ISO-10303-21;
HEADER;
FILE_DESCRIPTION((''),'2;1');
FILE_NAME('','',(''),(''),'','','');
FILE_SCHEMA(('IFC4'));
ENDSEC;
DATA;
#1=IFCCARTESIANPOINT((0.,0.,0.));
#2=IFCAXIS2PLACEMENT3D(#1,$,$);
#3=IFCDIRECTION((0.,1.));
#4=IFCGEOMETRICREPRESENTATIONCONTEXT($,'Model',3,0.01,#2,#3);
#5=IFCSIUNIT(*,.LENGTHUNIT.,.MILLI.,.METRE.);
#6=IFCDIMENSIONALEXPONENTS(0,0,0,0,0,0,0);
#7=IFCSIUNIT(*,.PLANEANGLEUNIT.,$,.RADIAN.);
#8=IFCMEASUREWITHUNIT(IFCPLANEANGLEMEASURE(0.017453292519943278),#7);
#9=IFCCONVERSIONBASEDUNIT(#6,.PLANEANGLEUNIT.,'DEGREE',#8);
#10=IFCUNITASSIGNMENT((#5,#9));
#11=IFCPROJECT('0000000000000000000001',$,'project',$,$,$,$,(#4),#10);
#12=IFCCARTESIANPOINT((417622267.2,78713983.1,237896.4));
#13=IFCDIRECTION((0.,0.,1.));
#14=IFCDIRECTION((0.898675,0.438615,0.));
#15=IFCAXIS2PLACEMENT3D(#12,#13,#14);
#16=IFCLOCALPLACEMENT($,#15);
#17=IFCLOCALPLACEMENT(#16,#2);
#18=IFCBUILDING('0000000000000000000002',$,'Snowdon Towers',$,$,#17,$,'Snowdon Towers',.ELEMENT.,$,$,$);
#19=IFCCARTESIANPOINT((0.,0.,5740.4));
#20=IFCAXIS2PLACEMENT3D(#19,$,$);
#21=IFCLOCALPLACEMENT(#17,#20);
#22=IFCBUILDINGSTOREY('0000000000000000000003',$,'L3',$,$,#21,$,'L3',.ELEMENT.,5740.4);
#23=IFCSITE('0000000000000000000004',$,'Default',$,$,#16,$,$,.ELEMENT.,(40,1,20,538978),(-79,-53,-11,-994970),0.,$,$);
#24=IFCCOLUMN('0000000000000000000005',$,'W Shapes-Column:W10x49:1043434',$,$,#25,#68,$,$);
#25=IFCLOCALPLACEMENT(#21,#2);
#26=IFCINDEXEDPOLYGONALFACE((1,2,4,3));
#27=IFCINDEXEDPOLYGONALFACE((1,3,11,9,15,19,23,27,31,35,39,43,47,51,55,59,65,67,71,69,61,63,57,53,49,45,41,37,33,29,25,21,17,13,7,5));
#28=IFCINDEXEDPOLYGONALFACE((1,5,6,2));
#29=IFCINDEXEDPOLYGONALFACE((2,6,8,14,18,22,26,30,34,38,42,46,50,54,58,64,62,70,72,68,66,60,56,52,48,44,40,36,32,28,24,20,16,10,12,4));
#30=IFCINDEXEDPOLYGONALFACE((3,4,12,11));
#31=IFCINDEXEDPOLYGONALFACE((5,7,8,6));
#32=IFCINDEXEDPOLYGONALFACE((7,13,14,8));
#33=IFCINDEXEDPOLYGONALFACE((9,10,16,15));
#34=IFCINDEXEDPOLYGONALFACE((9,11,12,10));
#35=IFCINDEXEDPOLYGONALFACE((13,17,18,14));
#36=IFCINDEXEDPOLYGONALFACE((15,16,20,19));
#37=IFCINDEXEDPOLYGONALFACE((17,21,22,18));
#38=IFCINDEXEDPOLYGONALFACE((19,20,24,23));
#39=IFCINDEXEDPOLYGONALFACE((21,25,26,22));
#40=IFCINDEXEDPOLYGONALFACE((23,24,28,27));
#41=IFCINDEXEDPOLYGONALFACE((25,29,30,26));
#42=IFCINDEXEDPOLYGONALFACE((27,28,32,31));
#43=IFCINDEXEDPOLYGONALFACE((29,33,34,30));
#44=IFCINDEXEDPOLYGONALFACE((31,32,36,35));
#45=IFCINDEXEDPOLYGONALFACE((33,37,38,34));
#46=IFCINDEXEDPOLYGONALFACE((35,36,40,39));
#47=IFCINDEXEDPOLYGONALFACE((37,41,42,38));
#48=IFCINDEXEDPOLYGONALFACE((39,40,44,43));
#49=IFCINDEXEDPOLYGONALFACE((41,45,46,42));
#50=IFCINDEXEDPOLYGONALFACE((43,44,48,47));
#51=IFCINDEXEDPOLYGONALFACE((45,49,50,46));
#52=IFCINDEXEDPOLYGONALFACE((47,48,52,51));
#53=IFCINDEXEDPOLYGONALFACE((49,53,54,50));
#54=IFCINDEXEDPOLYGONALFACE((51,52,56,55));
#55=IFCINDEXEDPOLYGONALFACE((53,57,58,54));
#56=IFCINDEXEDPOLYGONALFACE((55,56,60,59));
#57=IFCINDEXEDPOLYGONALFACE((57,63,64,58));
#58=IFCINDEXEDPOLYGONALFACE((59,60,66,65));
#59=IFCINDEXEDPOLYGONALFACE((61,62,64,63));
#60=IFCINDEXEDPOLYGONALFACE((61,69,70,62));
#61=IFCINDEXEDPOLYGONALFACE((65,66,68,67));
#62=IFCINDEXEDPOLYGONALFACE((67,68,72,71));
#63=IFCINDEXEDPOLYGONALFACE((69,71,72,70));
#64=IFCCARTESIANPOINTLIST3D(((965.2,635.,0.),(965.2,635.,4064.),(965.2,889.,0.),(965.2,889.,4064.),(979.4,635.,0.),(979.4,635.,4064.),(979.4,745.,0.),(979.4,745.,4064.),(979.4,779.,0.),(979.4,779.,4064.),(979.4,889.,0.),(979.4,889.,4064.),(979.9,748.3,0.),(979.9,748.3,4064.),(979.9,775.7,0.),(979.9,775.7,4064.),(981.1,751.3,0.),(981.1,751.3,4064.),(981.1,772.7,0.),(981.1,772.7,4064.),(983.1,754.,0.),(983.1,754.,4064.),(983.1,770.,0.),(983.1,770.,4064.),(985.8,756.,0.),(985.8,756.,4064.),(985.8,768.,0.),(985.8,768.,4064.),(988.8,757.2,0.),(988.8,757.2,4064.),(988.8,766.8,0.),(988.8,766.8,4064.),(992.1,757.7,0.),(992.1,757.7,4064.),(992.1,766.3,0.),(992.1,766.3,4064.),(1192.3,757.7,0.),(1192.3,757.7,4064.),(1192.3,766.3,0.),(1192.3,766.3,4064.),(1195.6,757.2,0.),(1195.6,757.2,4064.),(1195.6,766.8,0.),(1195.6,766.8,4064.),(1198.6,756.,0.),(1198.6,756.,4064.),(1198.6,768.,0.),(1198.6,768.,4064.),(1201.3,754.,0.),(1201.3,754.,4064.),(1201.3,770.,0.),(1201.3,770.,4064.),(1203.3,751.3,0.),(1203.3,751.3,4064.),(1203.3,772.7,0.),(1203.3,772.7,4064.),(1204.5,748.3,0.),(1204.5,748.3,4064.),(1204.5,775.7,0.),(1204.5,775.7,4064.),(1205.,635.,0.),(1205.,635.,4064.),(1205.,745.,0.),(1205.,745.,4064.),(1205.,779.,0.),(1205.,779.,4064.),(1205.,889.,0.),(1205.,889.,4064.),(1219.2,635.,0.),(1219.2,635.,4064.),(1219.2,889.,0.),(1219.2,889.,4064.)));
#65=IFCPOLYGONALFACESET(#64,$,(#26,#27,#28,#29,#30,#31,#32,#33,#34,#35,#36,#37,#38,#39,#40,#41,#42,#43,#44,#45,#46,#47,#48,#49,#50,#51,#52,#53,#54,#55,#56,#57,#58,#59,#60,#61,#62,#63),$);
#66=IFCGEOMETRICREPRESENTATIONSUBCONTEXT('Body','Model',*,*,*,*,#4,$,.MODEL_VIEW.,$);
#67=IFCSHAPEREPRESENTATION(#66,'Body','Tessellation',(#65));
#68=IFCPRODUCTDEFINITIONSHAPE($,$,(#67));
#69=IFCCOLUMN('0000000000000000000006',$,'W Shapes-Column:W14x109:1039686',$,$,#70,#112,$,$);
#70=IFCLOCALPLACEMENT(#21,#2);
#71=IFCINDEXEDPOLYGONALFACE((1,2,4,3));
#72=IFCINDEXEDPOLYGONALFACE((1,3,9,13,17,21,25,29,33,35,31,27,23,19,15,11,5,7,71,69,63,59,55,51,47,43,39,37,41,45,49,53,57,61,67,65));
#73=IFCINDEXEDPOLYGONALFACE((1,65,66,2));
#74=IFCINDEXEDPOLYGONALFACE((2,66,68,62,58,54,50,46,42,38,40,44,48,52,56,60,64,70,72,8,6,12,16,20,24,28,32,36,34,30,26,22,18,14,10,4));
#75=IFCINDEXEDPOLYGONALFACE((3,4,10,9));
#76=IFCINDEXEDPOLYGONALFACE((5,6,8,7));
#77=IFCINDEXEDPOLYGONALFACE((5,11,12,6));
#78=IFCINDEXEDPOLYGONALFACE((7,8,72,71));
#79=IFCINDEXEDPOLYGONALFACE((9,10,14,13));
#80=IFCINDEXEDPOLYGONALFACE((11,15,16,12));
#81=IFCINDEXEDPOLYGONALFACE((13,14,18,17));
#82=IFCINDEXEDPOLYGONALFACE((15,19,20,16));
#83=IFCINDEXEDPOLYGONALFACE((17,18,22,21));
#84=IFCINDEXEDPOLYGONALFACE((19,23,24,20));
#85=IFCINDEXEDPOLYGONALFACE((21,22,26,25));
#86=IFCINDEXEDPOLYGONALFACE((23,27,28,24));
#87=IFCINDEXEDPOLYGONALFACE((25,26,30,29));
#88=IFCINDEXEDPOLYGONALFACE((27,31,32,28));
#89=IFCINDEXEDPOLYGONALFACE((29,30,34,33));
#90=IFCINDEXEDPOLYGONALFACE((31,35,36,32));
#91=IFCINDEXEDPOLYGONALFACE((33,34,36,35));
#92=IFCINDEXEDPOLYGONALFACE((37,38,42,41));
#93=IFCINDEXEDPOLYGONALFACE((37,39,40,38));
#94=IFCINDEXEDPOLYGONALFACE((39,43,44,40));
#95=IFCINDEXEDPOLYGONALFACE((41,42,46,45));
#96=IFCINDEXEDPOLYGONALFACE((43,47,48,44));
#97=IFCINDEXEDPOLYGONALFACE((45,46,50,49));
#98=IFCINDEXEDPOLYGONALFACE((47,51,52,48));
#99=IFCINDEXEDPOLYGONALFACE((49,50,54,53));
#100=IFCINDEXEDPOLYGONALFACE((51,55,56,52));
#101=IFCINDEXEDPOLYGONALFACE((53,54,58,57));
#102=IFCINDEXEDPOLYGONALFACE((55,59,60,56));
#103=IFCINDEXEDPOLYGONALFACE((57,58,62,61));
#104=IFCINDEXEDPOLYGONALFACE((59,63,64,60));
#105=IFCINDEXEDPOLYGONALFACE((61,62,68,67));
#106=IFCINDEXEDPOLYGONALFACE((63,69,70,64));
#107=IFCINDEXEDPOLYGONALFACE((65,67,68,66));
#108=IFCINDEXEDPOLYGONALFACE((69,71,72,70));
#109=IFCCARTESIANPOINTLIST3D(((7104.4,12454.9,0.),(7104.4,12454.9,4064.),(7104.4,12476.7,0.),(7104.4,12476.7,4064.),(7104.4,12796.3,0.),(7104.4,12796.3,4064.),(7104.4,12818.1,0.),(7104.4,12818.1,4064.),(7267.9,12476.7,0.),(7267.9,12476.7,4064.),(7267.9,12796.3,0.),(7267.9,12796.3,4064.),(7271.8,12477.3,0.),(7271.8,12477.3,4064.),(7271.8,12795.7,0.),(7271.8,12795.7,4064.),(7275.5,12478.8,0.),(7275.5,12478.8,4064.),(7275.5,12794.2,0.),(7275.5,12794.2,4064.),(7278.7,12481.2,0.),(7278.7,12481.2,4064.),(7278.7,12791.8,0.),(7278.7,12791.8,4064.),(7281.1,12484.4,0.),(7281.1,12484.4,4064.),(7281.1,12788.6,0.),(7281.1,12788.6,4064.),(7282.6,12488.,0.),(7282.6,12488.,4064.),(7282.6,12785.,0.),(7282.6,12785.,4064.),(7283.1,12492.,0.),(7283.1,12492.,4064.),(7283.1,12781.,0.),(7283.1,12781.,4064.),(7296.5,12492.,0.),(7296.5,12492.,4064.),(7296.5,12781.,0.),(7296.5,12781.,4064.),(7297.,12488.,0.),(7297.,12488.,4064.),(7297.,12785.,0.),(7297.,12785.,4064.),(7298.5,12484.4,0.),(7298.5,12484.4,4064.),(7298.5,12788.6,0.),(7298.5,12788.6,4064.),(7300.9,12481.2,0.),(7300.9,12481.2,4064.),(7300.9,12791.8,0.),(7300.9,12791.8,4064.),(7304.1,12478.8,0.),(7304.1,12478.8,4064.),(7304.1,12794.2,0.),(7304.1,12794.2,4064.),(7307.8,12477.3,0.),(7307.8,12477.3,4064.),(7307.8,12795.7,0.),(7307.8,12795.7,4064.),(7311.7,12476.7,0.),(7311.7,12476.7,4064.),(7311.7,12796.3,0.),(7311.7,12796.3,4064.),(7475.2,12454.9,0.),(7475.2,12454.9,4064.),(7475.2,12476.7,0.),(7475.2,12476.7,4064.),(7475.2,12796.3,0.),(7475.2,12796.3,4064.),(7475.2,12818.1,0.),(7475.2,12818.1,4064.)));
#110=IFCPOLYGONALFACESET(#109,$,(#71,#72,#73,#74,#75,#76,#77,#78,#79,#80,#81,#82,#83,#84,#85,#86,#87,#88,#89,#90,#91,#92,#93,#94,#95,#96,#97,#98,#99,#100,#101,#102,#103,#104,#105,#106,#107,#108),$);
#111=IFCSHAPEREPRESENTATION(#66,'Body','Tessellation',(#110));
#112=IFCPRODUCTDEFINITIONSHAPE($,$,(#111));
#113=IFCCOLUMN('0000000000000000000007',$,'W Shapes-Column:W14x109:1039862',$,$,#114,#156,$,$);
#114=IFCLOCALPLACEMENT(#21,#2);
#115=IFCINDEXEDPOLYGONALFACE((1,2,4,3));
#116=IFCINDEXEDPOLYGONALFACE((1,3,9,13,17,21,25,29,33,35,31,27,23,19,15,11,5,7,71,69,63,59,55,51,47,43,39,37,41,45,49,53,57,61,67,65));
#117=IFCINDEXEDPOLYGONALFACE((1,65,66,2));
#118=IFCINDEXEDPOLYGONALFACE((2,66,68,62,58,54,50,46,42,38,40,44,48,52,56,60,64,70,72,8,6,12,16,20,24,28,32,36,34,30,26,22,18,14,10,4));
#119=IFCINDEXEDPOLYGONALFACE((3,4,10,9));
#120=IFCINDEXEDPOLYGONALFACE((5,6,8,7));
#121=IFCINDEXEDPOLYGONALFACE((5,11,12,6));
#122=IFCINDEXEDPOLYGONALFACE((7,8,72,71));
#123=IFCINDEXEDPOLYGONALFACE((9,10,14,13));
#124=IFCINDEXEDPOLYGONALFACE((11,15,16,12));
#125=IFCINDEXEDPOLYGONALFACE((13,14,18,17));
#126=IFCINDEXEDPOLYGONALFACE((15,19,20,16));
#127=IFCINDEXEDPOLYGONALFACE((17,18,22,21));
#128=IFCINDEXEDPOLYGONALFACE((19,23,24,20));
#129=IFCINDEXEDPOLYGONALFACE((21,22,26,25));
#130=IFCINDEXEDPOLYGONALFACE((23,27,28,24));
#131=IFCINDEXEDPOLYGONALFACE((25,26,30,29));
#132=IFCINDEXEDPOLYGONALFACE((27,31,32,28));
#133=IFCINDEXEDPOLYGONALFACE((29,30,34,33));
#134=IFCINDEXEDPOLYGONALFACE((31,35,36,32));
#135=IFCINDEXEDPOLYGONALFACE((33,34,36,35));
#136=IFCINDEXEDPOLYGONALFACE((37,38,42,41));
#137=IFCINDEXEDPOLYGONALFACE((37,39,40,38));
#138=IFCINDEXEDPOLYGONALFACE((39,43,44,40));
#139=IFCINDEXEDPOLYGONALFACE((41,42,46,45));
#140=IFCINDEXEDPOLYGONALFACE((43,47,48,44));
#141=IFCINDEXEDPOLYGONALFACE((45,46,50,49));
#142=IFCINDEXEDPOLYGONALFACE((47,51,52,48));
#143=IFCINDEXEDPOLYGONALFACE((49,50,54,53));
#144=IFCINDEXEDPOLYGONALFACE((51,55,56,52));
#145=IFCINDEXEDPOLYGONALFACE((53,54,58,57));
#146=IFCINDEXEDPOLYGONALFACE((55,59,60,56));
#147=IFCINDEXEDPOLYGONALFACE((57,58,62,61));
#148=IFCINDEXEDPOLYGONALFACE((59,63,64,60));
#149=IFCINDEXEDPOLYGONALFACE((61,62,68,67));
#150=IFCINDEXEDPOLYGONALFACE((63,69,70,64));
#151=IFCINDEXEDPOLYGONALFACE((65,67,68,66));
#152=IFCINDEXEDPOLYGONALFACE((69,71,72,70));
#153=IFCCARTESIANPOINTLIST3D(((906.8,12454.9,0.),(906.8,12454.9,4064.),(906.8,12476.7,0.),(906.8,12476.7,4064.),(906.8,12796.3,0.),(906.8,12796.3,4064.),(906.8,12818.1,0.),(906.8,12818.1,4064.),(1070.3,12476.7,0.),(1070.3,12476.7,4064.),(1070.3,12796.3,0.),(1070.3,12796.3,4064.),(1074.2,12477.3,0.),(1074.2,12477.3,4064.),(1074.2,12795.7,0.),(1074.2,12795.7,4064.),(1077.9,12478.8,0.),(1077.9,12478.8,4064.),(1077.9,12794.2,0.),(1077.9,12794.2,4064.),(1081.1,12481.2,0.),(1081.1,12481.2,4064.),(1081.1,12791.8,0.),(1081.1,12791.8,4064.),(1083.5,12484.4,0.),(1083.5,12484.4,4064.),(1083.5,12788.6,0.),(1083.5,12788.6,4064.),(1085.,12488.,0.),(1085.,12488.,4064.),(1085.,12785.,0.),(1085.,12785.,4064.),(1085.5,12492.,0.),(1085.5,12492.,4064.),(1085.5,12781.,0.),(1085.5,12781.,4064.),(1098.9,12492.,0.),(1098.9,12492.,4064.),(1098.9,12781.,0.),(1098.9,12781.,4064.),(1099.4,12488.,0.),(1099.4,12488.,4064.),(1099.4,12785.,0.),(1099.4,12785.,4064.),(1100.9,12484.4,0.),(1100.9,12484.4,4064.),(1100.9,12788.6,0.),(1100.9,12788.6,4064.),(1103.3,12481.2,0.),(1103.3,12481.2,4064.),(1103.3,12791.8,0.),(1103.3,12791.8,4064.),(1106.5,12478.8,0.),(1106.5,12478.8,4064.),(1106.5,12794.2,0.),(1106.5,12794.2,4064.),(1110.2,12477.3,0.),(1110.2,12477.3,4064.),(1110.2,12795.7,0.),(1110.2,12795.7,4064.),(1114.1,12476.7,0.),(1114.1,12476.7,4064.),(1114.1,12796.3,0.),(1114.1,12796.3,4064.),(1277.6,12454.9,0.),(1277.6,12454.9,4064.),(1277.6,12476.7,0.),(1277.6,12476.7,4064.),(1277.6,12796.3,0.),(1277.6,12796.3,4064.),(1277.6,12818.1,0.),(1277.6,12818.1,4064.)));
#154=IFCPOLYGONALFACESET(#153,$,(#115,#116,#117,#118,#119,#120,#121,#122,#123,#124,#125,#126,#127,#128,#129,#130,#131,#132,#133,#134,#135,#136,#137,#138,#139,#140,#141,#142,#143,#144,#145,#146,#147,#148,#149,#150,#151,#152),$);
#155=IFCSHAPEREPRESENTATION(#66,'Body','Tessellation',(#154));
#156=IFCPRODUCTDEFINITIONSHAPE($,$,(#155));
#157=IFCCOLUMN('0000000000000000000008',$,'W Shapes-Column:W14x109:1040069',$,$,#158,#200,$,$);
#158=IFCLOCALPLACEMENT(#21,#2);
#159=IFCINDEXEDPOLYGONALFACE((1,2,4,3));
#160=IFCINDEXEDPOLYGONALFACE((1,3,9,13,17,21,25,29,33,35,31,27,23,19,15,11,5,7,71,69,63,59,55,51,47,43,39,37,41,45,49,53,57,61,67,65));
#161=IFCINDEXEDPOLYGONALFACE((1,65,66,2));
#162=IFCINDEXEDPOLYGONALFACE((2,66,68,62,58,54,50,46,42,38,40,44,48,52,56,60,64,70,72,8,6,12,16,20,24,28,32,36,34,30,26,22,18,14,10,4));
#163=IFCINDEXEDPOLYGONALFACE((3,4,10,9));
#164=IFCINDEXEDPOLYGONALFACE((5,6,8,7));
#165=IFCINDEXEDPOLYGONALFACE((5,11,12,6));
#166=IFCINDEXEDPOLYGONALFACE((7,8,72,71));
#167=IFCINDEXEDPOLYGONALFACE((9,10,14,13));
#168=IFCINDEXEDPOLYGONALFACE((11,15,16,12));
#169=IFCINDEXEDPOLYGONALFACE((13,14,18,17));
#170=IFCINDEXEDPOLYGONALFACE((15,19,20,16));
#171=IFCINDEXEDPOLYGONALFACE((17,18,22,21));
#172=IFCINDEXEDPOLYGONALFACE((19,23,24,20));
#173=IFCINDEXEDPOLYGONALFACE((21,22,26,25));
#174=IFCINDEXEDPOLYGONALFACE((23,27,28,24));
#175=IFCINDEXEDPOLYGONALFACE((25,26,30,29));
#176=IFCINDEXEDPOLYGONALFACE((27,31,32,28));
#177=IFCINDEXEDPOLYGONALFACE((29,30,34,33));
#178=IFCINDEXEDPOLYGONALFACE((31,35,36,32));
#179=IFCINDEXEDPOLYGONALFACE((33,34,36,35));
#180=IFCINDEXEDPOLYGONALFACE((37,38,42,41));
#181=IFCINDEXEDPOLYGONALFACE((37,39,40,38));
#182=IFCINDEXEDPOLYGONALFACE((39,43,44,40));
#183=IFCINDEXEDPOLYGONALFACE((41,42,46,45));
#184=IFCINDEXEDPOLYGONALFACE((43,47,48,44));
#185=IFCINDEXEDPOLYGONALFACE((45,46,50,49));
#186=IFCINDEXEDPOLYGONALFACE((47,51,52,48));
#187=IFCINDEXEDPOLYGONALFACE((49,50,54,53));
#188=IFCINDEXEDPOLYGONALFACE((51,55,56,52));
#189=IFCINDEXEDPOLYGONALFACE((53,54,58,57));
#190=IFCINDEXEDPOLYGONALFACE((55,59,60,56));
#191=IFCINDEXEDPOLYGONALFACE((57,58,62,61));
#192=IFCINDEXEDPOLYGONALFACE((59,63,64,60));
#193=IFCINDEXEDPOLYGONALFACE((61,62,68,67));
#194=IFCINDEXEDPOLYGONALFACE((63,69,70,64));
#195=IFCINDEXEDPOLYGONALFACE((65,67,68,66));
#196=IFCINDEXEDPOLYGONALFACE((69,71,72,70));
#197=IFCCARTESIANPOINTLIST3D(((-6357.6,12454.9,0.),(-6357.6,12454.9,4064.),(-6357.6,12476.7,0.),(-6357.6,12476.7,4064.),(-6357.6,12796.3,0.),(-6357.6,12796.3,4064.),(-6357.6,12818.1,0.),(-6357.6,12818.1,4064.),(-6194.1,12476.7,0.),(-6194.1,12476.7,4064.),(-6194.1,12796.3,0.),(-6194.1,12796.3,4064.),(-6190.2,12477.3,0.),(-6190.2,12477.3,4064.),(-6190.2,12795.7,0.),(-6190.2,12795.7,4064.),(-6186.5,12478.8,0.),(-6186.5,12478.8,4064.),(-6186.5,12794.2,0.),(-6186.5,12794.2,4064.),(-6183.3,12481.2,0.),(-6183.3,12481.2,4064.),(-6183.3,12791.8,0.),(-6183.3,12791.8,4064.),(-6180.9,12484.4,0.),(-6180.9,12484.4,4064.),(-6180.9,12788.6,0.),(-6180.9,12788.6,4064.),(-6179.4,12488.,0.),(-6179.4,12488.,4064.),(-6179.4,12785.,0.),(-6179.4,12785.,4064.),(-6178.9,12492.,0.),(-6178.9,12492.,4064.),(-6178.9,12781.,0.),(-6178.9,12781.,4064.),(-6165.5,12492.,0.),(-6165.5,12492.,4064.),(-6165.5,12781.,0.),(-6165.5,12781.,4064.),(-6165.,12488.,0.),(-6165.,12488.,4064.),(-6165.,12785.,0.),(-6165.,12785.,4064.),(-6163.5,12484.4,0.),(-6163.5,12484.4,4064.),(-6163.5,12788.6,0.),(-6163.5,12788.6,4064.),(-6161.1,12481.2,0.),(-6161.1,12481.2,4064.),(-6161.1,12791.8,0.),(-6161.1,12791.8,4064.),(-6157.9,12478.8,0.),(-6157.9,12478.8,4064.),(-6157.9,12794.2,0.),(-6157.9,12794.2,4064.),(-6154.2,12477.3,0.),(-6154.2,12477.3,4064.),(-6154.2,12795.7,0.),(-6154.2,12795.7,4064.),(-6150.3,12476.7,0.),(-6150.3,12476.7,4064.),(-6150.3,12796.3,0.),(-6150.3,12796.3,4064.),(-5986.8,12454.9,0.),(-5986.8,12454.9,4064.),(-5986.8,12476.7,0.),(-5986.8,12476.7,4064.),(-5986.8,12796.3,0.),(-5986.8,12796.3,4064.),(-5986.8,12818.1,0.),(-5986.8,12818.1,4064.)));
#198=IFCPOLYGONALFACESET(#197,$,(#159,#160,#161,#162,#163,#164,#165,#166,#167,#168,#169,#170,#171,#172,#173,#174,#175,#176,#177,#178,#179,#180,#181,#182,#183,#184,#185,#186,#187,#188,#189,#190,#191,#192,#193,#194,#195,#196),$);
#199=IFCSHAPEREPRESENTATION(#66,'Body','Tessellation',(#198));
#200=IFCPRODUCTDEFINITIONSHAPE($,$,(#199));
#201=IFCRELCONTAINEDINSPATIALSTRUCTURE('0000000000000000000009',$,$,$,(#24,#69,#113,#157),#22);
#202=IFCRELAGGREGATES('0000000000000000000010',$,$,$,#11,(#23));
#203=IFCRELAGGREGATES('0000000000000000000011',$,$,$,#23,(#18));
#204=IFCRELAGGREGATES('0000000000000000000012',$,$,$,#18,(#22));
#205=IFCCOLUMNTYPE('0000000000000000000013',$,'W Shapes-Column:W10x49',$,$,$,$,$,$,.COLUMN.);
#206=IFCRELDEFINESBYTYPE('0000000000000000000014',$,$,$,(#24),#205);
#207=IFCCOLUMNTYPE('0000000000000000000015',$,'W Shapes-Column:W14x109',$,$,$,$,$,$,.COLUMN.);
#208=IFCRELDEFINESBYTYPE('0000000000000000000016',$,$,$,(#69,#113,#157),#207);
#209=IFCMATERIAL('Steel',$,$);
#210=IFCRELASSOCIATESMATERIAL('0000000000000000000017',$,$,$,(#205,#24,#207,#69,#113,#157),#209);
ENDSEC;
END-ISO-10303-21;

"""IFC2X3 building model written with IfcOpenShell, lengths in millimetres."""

from ifc_helpers import new_model, entity, si_unit, converted_unit, direction, frame, frame_2d, origin, place, context, subcontext, project, spatial, i_section, extrude, source, transform, mapped, material, type_object, type_shapes, element, save


model = new_model("IFC2X3")

# Units and contexts
model_context = context("Model", 3, precision=0.01, world=origin(), true_north=direction((0.0, 1.0)))
body_context = subcontext(model_context, "Body", "Model", "MODEL_VIEW")
ifc_project = project(units=[si_unit("LENGTHUNIT", "METRE", prefix="MILLI"), converted_unit("PLANEANGLEUNIT", "DEGREE", entity("IfcPlaneAngleMeasure", 0.017453292519943278), si_unit("PLANEANGLEUNIT", "RADIAN"), dimensions=[0, 0, 0, 0, 0, 0, 0])], contexts=[model_context])

# Site, building, storey
site_placement = place(None, frame((417622267.2, 78713983.1, 237896.4), z_axis=(0.0, 0.0, 1.0), x_axis=(0.898675, 0.438615, 0.0)))
site = spatial("IfcSite", under=ifc_project, at=site_placement, Name="Default", CompositionType="ELEMENT", RefLatitude=(40, 1, 20, 538978), RefLongitude=(-79, -53, -11, -994970), RefElevation=0.0)
building_placement = place(site_placement, origin())
building = spatial("IfcBuilding", under=site, at=building_placement, Name="Snowdon Towers", LongName="Snowdon Towers", CompositionType="ELEMENT")
storey_placement = place(building_placement, frame((0.0, 0.0, 5740.4)))
storey = spatial("IfcBuildingStorey", under=building, at=storey_placement, Name="L3", LongName="L3", CompositionType="ELEMENT", Elevation=5740.4)

# Columns
ifc_material_1 = material(Name="Steel")
column_type_1 = type_object("IfcColumnType", Name="W Shapes-Column:W10x49", PredefinedType="COLUMN", material=ifc_material_1)
shared_shape_1 = source(origin(), body_context, "Body", "SweptSolid", [
    extrude(i_section(OverallWidth=254.0, OverallDepth=254.0, WebThickness=8.6, FlangeThickness=14.2, FilletRadius=12.7, at=frame_2d((0.0, 0.0), x_axis=(1.0, 0.0))), frame((0.0, 0.0, 5740.4), z_axis=(0.0, 0.0, 1.0), x_axis=(-1.0, 0.0, 0.0)), (0.0, 0.0, 1.0), 4064.0),
])
type_shapes(column_type_1, [shared_shape_1])
for number, where, z_axis, x_axis, name in (
    (1, (1092.2, 762.0, -5740.4), (0.0, 0.0, 1.0), (0.0, 1.0, 0.0), "W Shapes-Column:W10x49:1043434"),
):
    element("IfcColumn", number, at=place(storey_placement, frame(where, z_axis=z_axis, x_axis=x_axis)), inside=storey, type_object=column_type_1, material=ifc_material_1, Name=name, context=body_context, shape_type="MappedRepresentation", body=[
        mapped(shared_shape_1, transform((0.0, 0.0, 0.0), scale=1.0)),
    ])
column_type_2 = type_object("IfcColumnType", Name="W Shapes-Column:W14x109", PredefinedType="COLUMN", material=ifc_material_1)
shared_shape_2 = source(origin(), body_context, "Body", "SweptSolid", [
    extrude(i_section(OverallWidth=370.8, OverallDepth=363.2, WebThickness=13.3, FlangeThickness=21.8, FilletRadius=15.2, at=frame_2d((0.0, 0.0), x_axis=(1.0, 0.0))), frame((0.0, 0.0, 5740.4), z_axis=(0.0, 0.0, 1.0), x_axis=(-1.0, 0.0, 0.0)), (0.0, 0.0, 1.0), 4064.0),
])
type_shapes(column_type_2, [shared_shape_2])
column_placement = place(storey_placement, frame((7289.8, 12636.5, -5740.4)))
element("IfcColumn", 2, at=column_placement, inside=storey, type_object=column_type_2, material=ifc_material_1, Name="W Shapes-Column:W14x109:1039686", context=body_context, shape_type="MappedRepresentation", body=[
    mapped(shared_shape_2, transform((0.0, 0.0, 0.0), scale=1.0)),
])
for number, where, z_axis, x_axis, name in (
    (3, (1092.2, 12636.5, -5740.4), (0.0, 0.0, 1.0), (-1.0, 0.0, 0.0), "W Shapes-Column:W14x109:1039862"),
    (4, (-6172.2, 12636.5, -5740.4), (0.0, 0.0, 1.0), (-1.0, 0.0, 0.0), "W Shapes-Column:W14x109:1040069"),
):
    element("IfcColumn", number, at=place(storey_placement, frame(where, z_axis=z_axis, x_axis=x_axis)), inside=storey, type_object=column_type_2, material=ifc_material_1, Name=name, context=body_context, shape_type="MappedRepresentation", body=[
        mapped(shared_shape_2, transform((0.0, 0.0, 0.0), scale=1.0)),
    ])

save(model, "model.ifc")
